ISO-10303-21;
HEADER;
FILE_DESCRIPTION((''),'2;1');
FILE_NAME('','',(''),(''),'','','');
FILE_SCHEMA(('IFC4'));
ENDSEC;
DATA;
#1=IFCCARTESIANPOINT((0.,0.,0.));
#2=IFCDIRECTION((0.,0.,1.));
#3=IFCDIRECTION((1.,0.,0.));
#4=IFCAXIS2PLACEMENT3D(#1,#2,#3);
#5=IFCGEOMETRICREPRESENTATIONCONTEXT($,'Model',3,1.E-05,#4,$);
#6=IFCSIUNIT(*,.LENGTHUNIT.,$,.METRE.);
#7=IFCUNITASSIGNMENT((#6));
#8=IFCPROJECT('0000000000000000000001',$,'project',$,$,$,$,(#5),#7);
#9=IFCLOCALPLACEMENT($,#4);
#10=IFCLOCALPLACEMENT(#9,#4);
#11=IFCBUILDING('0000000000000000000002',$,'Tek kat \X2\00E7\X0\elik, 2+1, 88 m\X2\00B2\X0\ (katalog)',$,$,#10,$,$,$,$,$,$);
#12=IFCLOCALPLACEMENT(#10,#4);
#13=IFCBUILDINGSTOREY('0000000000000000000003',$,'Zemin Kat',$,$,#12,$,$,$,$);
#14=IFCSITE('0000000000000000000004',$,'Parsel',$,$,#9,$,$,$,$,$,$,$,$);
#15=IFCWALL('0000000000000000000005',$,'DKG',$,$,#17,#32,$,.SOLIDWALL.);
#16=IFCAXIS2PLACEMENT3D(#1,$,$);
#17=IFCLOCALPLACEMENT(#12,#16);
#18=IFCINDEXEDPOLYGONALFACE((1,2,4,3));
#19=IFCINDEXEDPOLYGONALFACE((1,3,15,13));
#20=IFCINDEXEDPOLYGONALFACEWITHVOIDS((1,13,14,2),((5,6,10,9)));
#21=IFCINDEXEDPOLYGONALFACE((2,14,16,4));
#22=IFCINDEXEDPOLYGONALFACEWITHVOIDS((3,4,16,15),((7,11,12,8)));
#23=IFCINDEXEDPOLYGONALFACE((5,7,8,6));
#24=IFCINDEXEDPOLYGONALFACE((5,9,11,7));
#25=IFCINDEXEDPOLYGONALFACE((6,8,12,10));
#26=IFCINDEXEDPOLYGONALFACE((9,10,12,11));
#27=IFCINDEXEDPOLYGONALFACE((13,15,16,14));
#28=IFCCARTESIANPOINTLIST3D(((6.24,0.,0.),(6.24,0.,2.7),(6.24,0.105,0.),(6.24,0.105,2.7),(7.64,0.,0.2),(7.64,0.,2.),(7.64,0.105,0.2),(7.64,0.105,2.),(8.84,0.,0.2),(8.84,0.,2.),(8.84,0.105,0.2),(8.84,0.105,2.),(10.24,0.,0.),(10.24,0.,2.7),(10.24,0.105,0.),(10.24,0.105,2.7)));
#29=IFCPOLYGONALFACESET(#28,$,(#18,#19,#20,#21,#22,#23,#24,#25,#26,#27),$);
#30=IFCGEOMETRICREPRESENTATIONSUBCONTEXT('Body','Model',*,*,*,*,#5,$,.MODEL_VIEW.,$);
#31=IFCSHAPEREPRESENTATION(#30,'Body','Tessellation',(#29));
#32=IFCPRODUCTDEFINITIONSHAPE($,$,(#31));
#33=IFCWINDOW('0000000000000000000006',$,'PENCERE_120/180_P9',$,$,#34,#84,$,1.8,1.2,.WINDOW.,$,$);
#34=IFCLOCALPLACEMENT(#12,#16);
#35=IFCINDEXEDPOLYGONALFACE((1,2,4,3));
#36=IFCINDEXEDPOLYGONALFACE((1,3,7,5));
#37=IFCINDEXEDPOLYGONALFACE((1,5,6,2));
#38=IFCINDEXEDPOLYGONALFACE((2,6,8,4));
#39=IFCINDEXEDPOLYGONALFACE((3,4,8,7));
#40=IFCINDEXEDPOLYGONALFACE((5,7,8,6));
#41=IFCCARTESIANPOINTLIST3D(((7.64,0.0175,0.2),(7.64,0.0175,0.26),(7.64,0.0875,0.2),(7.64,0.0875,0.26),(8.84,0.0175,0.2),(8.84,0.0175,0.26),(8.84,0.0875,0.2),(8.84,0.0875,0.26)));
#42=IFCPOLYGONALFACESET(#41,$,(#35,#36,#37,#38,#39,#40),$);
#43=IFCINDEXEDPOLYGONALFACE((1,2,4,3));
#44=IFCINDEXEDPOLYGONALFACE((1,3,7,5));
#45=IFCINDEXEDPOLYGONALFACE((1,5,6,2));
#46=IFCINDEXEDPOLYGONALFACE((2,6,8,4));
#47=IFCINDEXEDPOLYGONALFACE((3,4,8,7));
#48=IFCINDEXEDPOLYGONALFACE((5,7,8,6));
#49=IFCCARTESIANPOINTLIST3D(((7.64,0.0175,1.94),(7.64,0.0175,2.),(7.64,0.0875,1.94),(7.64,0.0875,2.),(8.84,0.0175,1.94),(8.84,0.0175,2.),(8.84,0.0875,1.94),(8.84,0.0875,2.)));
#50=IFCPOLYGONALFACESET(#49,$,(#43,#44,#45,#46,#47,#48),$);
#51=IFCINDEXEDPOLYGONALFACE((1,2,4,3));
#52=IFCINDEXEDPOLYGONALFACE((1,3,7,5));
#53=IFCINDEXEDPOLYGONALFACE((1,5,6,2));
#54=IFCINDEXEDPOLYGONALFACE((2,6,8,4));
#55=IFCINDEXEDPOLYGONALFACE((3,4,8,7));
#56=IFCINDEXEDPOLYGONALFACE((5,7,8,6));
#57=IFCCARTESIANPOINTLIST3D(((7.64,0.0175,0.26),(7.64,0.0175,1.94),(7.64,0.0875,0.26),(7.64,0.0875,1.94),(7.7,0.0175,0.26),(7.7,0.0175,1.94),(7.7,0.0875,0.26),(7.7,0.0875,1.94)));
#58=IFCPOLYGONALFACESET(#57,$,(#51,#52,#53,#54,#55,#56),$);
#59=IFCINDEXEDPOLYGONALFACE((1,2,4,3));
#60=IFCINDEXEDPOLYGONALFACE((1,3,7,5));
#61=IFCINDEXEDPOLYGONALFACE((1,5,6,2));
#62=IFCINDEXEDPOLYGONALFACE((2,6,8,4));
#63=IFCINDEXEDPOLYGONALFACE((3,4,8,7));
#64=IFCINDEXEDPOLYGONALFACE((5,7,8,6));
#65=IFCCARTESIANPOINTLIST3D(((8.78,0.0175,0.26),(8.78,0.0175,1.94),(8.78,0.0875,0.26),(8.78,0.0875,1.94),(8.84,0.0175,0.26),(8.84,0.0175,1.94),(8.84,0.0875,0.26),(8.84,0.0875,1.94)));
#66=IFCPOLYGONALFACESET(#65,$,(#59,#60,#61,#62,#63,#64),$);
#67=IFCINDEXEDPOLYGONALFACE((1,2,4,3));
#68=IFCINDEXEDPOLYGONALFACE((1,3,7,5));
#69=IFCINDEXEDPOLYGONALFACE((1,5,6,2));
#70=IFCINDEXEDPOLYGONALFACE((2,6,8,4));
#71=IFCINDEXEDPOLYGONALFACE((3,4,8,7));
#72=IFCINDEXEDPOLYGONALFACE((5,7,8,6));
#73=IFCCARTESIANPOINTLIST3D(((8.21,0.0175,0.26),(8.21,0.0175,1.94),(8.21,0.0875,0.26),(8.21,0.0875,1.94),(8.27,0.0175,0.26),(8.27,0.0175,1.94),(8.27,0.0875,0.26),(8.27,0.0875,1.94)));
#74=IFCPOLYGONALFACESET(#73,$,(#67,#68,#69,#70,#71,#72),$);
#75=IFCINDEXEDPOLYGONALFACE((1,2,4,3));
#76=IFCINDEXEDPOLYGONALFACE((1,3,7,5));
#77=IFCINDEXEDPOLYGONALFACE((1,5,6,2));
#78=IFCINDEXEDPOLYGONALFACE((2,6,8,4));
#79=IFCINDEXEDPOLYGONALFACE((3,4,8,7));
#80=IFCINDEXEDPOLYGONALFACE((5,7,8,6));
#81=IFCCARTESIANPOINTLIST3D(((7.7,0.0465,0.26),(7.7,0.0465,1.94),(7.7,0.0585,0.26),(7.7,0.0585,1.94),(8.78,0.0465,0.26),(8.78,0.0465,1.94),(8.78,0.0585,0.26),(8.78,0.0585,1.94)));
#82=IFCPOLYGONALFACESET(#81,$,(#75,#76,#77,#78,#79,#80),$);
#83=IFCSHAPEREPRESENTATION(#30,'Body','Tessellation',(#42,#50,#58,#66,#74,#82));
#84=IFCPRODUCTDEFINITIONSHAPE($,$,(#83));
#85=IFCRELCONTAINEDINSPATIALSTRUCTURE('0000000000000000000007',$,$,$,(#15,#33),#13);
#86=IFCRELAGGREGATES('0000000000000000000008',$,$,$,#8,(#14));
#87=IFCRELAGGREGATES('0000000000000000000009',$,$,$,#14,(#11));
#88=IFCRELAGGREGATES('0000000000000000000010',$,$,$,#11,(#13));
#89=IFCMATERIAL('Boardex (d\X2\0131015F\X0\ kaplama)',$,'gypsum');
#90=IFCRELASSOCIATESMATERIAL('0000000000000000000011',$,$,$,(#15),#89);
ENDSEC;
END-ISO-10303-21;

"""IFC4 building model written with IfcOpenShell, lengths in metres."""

from ifc_helpers import new_model, si_unit, frame, origin_with_axes, place, context, subcontext, project, spatial, line, indexed_curve, outline, extrude, material, element, fill, save


model = new_model("IFC4")

# Units and contexts
model_context = context("Model", 3, precision=1e-05, world=origin_with_axes())
body_context = subcontext(model_context, "Body", "Model", "MODEL_VIEW")
ifc_project = project(units=[si_unit("LENGTHUNIT", "METRE")], contexts=[model_context])

# Site, building, storey
site_placement = place(None, origin_with_axes())
site = spatial("IfcSite", under=ifc_project, at=site_placement, Name="Parsel")
building_placement = place(site_placement, origin_with_axes())
building = spatial("IfcBuilding", under=site, at=building_placement, Name="Tek kat çelik, 2+1, 88 m² (katalog)")
storey_placement = place(building_placement, origin_with_axes())
storey = spatial("IfcBuildingStorey", under=building, at=storey_placement, Name="Zemin Kat")

# Shared definitions
ifc_material = material(Name="Boardex (dış kaplama)", Category="gypsum")

# Wall, opening, window
wall_1_placement = place(storey_placement, origin_with_axes())
wall_1 = element("IfcWall", 1, at=wall_1_placement, inside=storey, material=ifc_material, Name="DKG", PredefinedType="SOLIDWALL", context=body_context, shape_type="SweptSolid", body=[
    extrude(outline(indexed_curve([(0.0, 0.0), (4.0, 0.0), (4.0, 0.105), (0.0, 0.105)], segments=[line(1, 2, 3, 4, 1)])), frame((6.24, 0.0, 0.0), z_axis=(0.0, 0.0, 1.0), x_axis=(1.0, 0.0, 0.0)), (0.0, 0.0, 1.0), 2.7),
])
opening_1_placement = place(wall_1_placement, origin_with_axes())
opening_1 = element("IfcOpeningElement", 2, at=opening_1_placement, cuts=wall_1, PredefinedType="OPENING", context=body_context, shape_type="SweptSolid", body=[
    extrude(outline(indexed_curve([(0.0, 0.0), (1.2, 0.0), (1.2, 0.145), (0.0, 0.145)], segments=[line(1, 2, 3, 4, 1)])), frame((7.64, -0.02, 0.2), z_axis=(0.0, 0.0, 1.0), x_axis=(1.0, 0.0, 0.0)), (0.0, 0.0, 1.0), 1.8),
])
window_1_placement = place(storey_placement, origin_with_axes())
window_1 = element("IfcWindow", 3, at=window_1_placement, inside=storey, Name="PENCERE_120/180_P9", OverallHeight=1.8, OverallWidth=1.2, PredefinedType="WINDOW", context=body_context, shape_type="SweptSolid", body=[
    extrude(outline(indexed_curve([(0.0, 0.0), (1.2, 0.0), (1.2, 0.07), (0.0, 0.07)], segments=[line(1, 2, 3, 4, 1)])), frame((7.64, 0.0175, 0.2), z_axis=(0.0, 0.0, 1.0), x_axis=(1.0, 0.0, 0.0)), (0.0, 0.0, 1.0), 0.06),
    extrude(outline(indexed_curve([(0.0, 0.0), (1.2, 0.0), (1.2, 0.07), (0.0, 0.07)], segments=[line(1, 2, 3, 4, 1)])), frame((7.64, 0.0175, 1.94), z_axis=(0.0, 0.0, 1.0), x_axis=(1.0, 0.0, 0.0)), (0.0, 0.0, 1.0), 0.06),
    extrude(outline(indexed_curve([(0.0, 0.0), (0.06, 0.0), (0.06, 0.07), (0.0, 0.07)], segments=[line(1, 2, 3, 4, 1)])), frame((7.64, 0.0175, 0.26), z_axis=(0.0, 0.0, 1.0), x_axis=(1.0, 0.0, 0.0)), (0.0, 0.0, 1.0), 1.68),
    extrude(outline(indexed_curve([(0.0, 0.0), (0.06, 0.0), (0.06, 0.07), (0.0, 0.07)], segments=[line(1, 2, 3, 4, 1)])), frame((8.78, 0.0175, 0.26), z_axis=(0.0, 0.0, 1.0), x_axis=(1.0, 0.0, 0.0)), (0.0, 0.0, 1.0), 1.68),
    extrude(outline(indexed_curve([(0.0, 0.0), (0.06, 0.0), (0.06, 0.07), (0.0, 0.07)], segments=[line(1, 2, 3, 4, 1)])), frame((8.21, 0.0175, 0.26), z_axis=(0.0, 0.0, 1.0), x_axis=(1.0, 0.0, 0.0)), (0.0, 0.0, 1.0), 1.68),
    extrude(outline(indexed_curve([(0.0, 0.0), (1.08, 0.0), (1.08, 0.012), (0.0, 0.012)], segments=[line(1, 2, 3, 4, 1)])), frame((7.7, 0.0465, 0.26), z_axis=(0.0, 0.0, 1.0), x_axis=(1.0, 0.0, 0.0)), (0.0, 0.0, 1.0), 1.68),
])
fill(opening_1, window_1)

save(model, "model.ifc")
